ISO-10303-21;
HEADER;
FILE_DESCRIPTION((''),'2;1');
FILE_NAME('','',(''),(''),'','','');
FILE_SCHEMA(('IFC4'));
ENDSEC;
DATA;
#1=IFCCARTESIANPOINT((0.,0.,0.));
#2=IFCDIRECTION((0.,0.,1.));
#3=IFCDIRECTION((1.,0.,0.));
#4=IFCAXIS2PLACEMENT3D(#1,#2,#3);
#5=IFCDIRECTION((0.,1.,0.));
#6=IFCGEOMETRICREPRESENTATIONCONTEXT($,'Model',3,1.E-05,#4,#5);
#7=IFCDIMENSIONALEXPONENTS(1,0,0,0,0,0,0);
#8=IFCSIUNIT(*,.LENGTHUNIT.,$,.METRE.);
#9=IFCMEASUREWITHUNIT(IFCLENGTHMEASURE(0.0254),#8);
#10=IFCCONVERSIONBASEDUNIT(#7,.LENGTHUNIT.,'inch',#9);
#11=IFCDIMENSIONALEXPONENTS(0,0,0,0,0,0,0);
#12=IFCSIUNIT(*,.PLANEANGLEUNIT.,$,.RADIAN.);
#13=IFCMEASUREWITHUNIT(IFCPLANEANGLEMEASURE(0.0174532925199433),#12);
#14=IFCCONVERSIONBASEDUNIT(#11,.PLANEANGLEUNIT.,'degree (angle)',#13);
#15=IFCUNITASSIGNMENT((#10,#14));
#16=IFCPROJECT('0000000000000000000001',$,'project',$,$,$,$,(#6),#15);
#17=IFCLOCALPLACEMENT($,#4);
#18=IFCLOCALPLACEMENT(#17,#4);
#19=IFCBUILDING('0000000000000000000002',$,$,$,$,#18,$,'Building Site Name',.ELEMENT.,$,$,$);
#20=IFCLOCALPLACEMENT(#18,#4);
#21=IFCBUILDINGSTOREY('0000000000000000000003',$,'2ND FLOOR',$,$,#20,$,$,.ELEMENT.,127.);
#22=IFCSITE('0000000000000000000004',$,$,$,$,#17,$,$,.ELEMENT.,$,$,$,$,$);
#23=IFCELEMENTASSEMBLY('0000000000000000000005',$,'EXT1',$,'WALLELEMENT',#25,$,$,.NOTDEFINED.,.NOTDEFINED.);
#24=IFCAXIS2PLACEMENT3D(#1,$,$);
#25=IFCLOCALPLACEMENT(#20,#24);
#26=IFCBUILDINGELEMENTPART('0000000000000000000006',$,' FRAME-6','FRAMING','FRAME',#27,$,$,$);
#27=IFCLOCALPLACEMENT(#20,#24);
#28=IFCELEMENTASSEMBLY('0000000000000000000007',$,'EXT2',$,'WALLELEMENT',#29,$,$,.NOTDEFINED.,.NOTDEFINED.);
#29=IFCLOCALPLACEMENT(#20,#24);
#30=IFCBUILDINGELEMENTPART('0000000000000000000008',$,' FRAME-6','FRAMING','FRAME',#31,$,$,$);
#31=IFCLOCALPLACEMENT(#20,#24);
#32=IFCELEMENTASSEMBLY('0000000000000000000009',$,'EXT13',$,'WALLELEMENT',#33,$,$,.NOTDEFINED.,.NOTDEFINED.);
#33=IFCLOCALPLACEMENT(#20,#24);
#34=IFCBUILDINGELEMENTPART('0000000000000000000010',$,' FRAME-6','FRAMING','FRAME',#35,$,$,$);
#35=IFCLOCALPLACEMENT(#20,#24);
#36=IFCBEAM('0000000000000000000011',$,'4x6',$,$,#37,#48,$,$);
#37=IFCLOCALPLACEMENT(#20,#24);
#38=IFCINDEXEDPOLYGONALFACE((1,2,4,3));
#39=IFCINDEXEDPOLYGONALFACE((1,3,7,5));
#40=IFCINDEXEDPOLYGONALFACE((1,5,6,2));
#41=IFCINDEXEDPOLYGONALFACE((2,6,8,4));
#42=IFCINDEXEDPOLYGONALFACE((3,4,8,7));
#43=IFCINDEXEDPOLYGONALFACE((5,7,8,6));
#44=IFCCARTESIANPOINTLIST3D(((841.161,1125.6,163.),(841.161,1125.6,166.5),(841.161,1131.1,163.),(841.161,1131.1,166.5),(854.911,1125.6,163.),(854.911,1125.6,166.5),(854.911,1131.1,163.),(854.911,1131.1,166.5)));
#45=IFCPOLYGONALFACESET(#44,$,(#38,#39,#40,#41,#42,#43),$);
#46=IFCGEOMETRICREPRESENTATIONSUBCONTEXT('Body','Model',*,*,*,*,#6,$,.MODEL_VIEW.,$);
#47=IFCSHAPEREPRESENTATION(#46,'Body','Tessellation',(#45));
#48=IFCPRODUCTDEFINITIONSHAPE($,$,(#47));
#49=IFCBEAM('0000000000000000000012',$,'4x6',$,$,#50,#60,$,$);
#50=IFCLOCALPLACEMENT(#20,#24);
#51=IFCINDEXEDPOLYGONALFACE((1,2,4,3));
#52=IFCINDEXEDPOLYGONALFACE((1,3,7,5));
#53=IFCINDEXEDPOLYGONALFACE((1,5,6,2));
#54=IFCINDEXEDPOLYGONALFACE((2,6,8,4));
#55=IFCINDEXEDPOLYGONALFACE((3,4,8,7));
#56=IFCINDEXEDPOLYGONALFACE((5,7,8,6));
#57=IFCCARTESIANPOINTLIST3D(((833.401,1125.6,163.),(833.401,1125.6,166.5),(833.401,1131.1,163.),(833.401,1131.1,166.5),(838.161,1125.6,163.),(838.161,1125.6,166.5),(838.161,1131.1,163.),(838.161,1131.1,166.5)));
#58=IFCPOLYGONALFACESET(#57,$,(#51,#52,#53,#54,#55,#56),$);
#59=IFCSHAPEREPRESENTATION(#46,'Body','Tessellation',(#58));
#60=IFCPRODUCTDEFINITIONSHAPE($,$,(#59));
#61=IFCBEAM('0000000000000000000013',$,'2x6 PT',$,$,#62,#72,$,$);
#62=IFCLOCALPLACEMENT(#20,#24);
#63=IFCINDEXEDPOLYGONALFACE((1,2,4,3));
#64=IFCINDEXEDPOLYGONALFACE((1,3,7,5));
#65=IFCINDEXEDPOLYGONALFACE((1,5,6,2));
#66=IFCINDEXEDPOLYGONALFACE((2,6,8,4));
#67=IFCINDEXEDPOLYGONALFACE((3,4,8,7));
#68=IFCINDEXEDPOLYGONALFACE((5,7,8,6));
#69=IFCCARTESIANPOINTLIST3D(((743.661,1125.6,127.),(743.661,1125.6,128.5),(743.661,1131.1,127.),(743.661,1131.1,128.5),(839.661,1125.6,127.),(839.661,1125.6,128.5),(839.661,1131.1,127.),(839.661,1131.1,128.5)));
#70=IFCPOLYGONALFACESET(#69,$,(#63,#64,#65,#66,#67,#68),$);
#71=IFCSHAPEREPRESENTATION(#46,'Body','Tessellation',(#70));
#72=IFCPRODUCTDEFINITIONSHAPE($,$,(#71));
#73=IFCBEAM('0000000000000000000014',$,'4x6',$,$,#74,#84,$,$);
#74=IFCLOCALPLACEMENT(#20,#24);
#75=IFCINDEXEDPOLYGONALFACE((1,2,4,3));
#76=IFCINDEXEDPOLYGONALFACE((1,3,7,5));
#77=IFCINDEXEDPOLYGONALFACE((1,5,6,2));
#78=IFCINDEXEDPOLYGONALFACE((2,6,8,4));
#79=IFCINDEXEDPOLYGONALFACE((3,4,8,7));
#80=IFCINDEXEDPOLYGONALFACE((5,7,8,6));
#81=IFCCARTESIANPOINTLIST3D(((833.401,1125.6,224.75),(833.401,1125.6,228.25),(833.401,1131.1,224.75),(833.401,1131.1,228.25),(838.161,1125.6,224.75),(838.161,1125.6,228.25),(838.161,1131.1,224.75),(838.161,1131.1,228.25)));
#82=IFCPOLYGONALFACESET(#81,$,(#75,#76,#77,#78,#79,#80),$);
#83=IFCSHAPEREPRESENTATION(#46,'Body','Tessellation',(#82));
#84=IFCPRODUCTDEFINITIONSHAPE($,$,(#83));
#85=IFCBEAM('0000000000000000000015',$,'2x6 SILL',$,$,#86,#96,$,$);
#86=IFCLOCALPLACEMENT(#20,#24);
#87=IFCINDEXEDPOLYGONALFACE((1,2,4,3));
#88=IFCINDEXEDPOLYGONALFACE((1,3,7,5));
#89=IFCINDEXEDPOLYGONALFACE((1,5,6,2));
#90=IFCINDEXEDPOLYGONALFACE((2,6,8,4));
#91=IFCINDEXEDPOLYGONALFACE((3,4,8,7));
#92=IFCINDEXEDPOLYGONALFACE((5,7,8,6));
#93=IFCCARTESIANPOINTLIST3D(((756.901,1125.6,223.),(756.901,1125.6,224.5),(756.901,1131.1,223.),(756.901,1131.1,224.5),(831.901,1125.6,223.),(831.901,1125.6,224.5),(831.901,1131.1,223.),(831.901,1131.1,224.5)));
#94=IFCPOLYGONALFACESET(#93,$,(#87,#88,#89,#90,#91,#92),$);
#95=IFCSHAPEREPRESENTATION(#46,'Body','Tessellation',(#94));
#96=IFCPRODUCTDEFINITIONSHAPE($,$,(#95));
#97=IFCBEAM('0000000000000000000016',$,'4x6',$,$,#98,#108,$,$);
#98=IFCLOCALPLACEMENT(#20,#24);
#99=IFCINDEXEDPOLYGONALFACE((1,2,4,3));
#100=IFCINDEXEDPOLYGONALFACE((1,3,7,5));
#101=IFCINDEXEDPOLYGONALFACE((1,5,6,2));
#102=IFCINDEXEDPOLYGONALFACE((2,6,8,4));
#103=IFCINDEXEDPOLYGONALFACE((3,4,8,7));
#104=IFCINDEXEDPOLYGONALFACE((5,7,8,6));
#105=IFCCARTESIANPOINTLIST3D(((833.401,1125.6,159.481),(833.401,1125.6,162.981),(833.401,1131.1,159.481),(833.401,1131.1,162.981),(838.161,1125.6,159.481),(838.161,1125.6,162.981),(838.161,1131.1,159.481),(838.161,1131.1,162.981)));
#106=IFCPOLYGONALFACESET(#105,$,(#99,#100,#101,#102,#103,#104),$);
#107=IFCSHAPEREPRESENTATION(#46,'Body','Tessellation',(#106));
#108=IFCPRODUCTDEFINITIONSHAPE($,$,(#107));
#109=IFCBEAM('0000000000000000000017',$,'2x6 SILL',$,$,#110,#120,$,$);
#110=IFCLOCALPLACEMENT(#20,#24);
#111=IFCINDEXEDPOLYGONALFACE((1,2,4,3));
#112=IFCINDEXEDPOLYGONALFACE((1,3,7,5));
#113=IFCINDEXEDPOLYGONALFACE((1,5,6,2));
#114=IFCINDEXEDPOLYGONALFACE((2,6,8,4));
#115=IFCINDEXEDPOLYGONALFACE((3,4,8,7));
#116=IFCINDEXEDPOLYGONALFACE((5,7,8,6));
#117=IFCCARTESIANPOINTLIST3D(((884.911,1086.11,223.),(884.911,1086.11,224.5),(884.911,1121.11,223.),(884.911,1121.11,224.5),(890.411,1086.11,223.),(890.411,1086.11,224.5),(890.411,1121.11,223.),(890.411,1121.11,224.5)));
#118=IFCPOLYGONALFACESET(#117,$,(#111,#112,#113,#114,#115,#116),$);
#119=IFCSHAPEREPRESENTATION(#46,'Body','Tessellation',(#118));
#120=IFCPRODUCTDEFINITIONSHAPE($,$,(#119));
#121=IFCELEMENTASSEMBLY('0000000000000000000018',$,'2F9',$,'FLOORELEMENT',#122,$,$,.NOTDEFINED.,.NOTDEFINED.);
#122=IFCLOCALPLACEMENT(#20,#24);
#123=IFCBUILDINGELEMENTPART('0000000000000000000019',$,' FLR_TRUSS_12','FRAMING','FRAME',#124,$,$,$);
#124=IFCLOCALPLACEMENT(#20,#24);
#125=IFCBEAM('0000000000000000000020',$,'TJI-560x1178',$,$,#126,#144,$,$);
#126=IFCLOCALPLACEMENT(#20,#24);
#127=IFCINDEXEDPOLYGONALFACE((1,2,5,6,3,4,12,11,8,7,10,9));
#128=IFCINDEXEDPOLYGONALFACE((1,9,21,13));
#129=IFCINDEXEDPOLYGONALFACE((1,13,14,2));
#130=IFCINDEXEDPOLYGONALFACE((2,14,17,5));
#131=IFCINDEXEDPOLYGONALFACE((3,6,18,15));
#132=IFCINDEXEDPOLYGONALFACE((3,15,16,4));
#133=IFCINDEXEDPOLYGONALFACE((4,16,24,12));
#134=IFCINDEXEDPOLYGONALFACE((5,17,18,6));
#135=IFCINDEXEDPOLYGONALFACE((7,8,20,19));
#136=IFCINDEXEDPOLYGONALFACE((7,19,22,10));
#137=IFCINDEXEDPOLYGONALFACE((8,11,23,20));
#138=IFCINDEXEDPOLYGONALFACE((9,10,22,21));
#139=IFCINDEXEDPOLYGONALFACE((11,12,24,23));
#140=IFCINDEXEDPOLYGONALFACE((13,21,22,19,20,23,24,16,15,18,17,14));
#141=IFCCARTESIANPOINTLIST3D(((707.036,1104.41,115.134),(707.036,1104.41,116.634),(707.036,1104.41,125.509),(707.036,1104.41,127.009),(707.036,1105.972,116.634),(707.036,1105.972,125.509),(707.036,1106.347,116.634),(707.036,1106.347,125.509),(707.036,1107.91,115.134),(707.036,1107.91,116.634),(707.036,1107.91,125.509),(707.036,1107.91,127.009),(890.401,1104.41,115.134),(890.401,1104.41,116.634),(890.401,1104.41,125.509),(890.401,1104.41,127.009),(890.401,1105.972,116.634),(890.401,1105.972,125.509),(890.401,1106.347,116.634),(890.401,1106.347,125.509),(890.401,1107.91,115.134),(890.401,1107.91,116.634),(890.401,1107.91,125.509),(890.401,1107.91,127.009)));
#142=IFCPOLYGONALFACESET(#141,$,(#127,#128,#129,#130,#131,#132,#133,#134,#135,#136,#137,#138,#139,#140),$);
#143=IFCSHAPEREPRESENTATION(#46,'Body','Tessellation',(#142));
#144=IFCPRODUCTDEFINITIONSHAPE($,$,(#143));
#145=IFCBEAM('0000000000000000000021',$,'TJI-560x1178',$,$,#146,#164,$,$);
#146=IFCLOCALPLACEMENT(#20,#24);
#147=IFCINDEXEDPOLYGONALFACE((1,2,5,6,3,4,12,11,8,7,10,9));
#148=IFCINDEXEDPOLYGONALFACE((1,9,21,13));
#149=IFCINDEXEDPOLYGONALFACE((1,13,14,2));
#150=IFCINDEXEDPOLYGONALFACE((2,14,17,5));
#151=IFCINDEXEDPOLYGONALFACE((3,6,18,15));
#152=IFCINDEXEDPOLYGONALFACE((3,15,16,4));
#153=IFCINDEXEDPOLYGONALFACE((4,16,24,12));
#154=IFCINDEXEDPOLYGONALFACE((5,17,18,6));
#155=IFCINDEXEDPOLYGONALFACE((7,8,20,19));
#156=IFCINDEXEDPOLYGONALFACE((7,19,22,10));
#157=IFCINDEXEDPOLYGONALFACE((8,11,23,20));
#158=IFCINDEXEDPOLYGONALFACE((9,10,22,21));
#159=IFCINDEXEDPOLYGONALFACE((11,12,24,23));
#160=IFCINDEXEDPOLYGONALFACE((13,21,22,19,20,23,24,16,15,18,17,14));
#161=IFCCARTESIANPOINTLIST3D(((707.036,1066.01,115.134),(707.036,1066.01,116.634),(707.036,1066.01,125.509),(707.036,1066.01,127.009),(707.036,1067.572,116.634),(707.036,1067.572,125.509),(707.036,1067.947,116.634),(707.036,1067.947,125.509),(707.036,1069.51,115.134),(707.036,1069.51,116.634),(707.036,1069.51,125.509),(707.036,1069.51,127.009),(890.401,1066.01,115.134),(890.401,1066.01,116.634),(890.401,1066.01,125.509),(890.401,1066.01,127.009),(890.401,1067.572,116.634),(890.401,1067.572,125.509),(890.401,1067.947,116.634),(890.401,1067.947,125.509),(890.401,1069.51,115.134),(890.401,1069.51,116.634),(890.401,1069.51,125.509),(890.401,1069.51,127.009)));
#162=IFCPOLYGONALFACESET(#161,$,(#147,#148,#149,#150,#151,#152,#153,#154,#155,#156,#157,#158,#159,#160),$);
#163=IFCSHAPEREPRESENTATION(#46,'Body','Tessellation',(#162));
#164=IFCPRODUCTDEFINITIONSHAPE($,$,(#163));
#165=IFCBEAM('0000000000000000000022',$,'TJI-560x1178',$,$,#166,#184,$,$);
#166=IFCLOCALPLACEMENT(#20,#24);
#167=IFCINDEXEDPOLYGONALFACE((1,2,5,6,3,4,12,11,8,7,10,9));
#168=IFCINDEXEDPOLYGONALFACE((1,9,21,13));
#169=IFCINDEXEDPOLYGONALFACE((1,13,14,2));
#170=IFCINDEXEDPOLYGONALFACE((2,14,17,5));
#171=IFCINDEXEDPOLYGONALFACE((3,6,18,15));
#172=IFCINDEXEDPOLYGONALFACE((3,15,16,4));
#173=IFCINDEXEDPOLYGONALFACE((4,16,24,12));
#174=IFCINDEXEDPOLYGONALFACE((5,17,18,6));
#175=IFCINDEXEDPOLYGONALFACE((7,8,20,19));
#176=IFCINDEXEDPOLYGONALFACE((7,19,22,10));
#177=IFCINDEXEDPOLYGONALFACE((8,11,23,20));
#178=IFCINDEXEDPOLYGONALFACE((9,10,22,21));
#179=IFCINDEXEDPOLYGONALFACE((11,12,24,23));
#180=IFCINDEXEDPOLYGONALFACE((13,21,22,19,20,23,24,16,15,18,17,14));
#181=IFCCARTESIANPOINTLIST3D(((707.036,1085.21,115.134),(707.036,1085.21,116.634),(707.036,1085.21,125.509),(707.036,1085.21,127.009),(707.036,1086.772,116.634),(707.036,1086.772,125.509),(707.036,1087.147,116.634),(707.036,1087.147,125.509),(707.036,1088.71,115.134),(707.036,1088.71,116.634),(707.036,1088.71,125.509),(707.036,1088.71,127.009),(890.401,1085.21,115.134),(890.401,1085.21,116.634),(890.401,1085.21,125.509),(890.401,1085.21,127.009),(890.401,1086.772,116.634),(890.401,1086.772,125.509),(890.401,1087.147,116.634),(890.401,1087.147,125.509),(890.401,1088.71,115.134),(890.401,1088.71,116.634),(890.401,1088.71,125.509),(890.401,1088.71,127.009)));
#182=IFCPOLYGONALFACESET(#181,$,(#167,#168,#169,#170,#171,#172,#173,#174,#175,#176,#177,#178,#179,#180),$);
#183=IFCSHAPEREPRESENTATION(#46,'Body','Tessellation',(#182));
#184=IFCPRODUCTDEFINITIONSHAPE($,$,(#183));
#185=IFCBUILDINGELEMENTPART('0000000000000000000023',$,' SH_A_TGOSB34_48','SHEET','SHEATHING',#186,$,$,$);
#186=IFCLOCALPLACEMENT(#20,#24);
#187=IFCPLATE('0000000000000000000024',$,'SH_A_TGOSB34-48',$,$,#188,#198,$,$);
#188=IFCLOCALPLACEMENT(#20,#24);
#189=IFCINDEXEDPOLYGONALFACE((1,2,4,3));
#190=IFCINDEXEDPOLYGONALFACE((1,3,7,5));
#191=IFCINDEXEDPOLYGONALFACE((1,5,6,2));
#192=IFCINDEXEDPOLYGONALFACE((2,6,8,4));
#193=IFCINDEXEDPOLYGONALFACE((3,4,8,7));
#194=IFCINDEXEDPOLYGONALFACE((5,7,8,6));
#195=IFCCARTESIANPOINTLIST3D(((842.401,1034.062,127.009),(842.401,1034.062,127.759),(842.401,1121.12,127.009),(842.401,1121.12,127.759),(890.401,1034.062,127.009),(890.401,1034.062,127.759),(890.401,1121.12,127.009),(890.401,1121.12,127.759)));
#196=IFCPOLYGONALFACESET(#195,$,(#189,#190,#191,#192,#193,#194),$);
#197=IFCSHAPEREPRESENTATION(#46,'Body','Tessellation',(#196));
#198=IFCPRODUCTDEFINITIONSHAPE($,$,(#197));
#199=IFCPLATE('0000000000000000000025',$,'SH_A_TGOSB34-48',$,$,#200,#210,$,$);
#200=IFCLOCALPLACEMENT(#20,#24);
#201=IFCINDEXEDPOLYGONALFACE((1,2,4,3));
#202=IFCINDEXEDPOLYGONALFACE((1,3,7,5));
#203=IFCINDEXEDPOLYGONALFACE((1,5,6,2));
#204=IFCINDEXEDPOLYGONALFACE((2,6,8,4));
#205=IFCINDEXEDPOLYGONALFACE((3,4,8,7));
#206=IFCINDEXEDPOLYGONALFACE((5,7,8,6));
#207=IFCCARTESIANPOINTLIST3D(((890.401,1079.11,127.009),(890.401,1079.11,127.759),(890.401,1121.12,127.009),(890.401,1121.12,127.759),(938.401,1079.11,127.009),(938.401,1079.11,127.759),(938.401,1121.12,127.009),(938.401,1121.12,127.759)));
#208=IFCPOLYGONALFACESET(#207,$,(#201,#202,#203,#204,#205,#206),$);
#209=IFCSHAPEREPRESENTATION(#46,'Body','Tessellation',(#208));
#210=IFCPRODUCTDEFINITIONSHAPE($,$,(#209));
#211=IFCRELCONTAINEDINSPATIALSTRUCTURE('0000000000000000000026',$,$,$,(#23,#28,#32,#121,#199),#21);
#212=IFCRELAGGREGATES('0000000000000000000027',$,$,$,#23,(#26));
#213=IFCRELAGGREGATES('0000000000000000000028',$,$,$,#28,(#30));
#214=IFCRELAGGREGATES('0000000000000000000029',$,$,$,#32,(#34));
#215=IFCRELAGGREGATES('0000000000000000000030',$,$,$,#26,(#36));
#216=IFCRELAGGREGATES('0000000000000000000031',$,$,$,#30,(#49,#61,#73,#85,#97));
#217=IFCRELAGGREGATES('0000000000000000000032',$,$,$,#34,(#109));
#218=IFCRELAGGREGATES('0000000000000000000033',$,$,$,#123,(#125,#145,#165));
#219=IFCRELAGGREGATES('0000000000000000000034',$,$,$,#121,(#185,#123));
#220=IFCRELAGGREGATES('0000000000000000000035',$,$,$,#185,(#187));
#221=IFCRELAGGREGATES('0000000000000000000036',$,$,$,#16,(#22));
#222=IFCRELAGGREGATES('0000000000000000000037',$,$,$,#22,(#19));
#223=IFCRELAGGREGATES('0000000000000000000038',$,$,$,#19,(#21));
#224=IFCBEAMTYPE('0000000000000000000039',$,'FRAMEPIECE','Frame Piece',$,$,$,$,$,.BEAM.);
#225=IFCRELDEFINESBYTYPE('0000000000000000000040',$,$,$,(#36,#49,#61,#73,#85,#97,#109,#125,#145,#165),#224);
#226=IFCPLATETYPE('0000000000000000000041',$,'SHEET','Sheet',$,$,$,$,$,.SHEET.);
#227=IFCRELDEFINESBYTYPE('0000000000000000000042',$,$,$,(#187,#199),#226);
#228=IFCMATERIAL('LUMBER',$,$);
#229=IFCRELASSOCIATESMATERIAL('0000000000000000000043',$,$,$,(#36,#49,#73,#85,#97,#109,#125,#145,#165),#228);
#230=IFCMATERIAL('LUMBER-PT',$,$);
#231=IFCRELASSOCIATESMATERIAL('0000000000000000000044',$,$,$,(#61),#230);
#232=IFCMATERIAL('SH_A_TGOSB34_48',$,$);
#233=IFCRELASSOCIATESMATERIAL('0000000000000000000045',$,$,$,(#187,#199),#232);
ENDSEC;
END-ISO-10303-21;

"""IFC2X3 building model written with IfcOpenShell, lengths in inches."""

from ifc_helpers import new_model, entity, si_unit, converted_unit, direction, frame, frame_2d, origin_with_axes, origin_2d_with_axis, place, context, subcontext, project, spatial, polyline, segment, composite_curve, rectangle, i_section, outline, extrude, material, type_object, element, aggregate, save


model = new_model("IFC2X3")

# Units and contexts
model_context = context("Model", 3, precision=1e-05, world=origin_with_axes(), true_north=direction((0.0, 1.0, 0.0)))
body_context = subcontext(model_context, "Body", "Model", "MODEL_VIEW")
ifc_project = project(units=[converted_unit("LENGTHUNIT", "inch", entity("IfcLengthMeasure", 0.0254), si_unit("LENGTHUNIT", "METRE"), dimensions=[1, 0, 0, 0, 0, 0, 0]), converted_unit("PLANEANGLEUNIT", "degree (angle)", entity("IfcPlaneAngleMeasure", 0.0174532925199433), si_unit("PLANEANGLEUNIT", "RADIAN"), dimensions=[0, 0, 0, 0, 0, 0, 0])], contexts=[model_context])

# Site, building, storey
site_placement = place(None, origin_with_axes())
site = spatial("IfcSite", under=ifc_project, at=site_placement, CompositionType="ELEMENT")
building_placement = place(site_placement, origin_with_axes())
building = spatial("IfcBuilding", under=site, at=building_placement, LongName="Building Site Name", CompositionType="ELEMENT")
storey_placement = place(building_placement, origin_with_axes())
storey = spatial("IfcBuildingStorey", under=building, at=storey_placement, Name="2ND FLOOR", CompositionType="ELEMENT", Elevation=127.0)

# Element assembly, building element part
assembly_1_placement = place(storey_placement, origin_with_axes())
assembly_1 = element("IfcElementAssembly", 1, at=assembly_1_placement, inside=storey, Name="EXT1", ObjectType="WALLELEMENT", AssemblyPlace="NOTDEFINED", PredefinedType="NOTDEFINED")
building_element_part_1 = element("IfcBuildingElementPart", 2, Name=" FRAME-6", Description="FRAMING", ObjectType="FRAME")
aggregate(assembly_1, [building_element_part_1])
ifc_material_1 = material(Name="LUMBER")
beam_type = type_object("IfcBeamType", Name="FRAMEPIECE", Description="Frame Piece", PredefinedType="BEAM")

# Element assemblies, building element parts
assembly_2_placement = place(storey_placement, origin_with_axes())
assembly_2 = element("IfcElementAssembly", 3, at=assembly_2_placement, inside=storey, Name="EXT2", ObjectType="WALLELEMENT", AssemblyPlace="NOTDEFINED", PredefinedType="NOTDEFINED")
building_element_part_2 = element("IfcBuildingElementPart", 4, Name=" FRAME-6", Description="FRAMING", ObjectType="FRAME")
aggregate(assembly_2, [building_element_part_2])
assembly_3_placement = place(storey_placement, origin_with_axes())
assembly_3 = element("IfcElementAssembly", 5, at=assembly_3_placement, inside=storey, Name="EXT13", ObjectType="WALLELEMENT", AssemblyPlace="NOTDEFINED", PredefinedType="NOTDEFINED")
building_element_part_3 = element("IfcBuildingElementPart", 6, Name=" FRAME-6", Description="FRAMING", ObjectType="FRAME")
aggregate(assembly_3, [building_element_part_3])

# Beams
ifc_material_2 = material(Name="LUMBER-PT")
beam_1_placement = place(assembly_1_placement, frame((841.161, 1128.35, 164.75), z_axis=(1.0, 0.0, 0.0), x_axis=(0.0, 0.0, -1.0)))
beam_1 = element("IfcBeam", 7, at=beam_1_placement, type_object=beam_type, material=ifc_material_1, Name="4x6", context=body_context, shape_type="SweptSolid", body=[
    extrude(outline(composite_curve([segment(polyline([(-1.75, -2.75), (-1.75, 2.75), (1.75, 2.75), (1.75, -2.75), (-1.75, -2.75)]), True, "CONTINUOUS")], self_intersect=False)), origin_with_axes(), (0.0, 0.0, 1.0), 13.75),
])
aggregate(building_element_part_1, [beam_1])
beam_2_placement = place(assembly_2_placement, frame((833.401, 1128.35, 164.75), z_axis=(1.0, 0.0, 0.0), x_axis=(0.0, 0.0, -1.0)))
beam_2 = element("IfcBeam", 8, at=beam_2_placement, type_object=beam_type, material=ifc_material_1, Name="4x6", context=body_context, shape_type="SweptSolid", body=[
    extrude(outline(composite_curve([segment(polyline([(-1.75, -2.75), (-1.75, 2.75), (1.75, 2.75), (1.75, -2.75), (-1.75, -2.75)]), True, "CONTINUOUS")], self_intersect=False)), origin_with_axes(), (0.0, 0.0, 1.0), 4.76),
])
beam_3_placement = place(assembly_2_placement, frame((839.661, 1128.35, 127.75), z_axis=(-1.0, 0.0, 0.0), x_axis=(0.0, 0.0, 1.0)))
beam_3 = element("IfcBeam", 9, at=beam_3_placement, type_object=beam_type, material=ifc_material_2, Name="2x6 PT", context=body_context, shape_type="SweptSolid", body=[
    extrude(rectangle(XDim=1.5, YDim=5.5, at=frame_2d((0.0, 0.0), x_axis=(-1.0, 0.0))), origin_with_axes(), (0.0, 0.0, 1.0), 96.0),
])
beam_4_placement = place(assembly_2_placement, frame((833.401, 1128.35, 226.5), z_axis=(1.0, 0.0, 0.0), x_axis=(0.0, 0.0, -1.0)))
beam_4 = element("IfcBeam", 10, at=beam_4_placement, type_object=beam_type, material=ifc_material_1, Name="4x6", context=body_context, shape_type="SweptSolid", body=[
    extrude(outline(composite_curve([segment(polyline([(-1.75, -2.75), (-1.75, 2.75), (1.75, 2.75), (1.75, -2.75), (-1.75, -2.75)]), True, "CONTINUOUS")], self_intersect=False)), origin_with_axes(), (0.0, 0.0, 1.0), 4.76),
])
beam_5_placement = place(assembly_2_placement, frame((831.901, 1128.35, 223.75), z_axis=(-1.0, 0.0, 0.0), x_axis=(0.0, 0.0, 1.0)))
beam_5 = element("IfcBeam", 11, at=beam_5_placement, type_object=beam_type, material=ifc_material_1, Name="2x6 SILL", context=body_context, shape_type="SweptSolid", body=[
    extrude(rectangle(XDim=1.5, YDim=5.5, at=frame_2d((0.0, 0.0), x_axis=(-1.0, 0.0))), frame((0.0, 0.0, 0.0), z_axis=(0.0, 0.0, 1.0), x_axis=(1.0, 0.0, 0.0)), (0.0, 0.0, 1.0), 75.0),
])
beam_6_placement = place(assembly_2_placement, frame((833.401, 1128.35, 161.231), z_axis=(1.0, 0.0, 0.0), x_axis=(0.0, 0.0, -1.0)))
beam_6 = element("IfcBeam", 12, at=beam_6_placement, type_object=beam_type, material=ifc_material_1, Name="4x6", context=body_context, shape_type="SweptSolid", body=[
    extrude(outline(composite_curve([segment(polyline([(-1.75, -2.75), (-1.75, 2.75), (1.75, 2.75), (1.75, -2.75), (-1.75, -2.75)]), True, "CONTINUOUS")], self_intersect=False)), origin_with_axes(), (0.0, 0.0, 1.0), 4.76),
])
aggregate(building_element_part_2, [beam_2, beam_3, beam_4, beam_5, beam_6])
beam_7_placement = place(assembly_3_placement, frame((887.661, 1086.11, 223.75), z_axis=(0.0, 1.0, 0.0), x_axis=(0.0, 0.0, 1.0)))
beam_7 = element("IfcBeam", 13, at=beam_7_placement, type_object=beam_type, material=ifc_material_1, Name="2x6 SILL", context=body_context, shape_type="SweptSolid", body=[
    extrude(rectangle(XDim=1.5, YDim=5.5, at=frame_2d((0.0, 0.0), x_axis=(-1.0, 0.0))), frame((0.0, 0.0, 0.0), z_axis=(0.0, 0.0, 1.0), x_axis=(1.0, 0.0, 0.0)), (0.0, 0.0, 1.0), 35.0),
])
aggregate(building_element_part_3, [beam_7])

# Element assembly, building element parts, beams, plate
assembly_4_placement = place(storey_placement, origin_with_axes())
assembly_4 = element("IfcElementAssembly", 14, at=assembly_4_placement, inside=storey, Name="2F9", ObjectType="FLOORELEMENT", AssemblyPlace="NOTDEFINED", PredefinedType="NOTDEFINED")
building_element_part_4 = element("IfcBuildingElementPart", 15, Name=" FLR_TRUSS_12", Description="FRAMING", ObjectType="FRAME")
beam_8_placement = place(assembly_4_placement, frame((890.401, 1106.16, 121.071), z_axis=(-1.0, 0.0, 0.0), x_axis=(0.0, -1.0, 0.0)))
beam_8 = element("IfcBeam", 16, at=beam_8_placement, type_object=beam_type, material=ifc_material_1, Name="TJI-560x1178", context=body_context, shape_type="SweptSolid", body=[
    extrude(i_section(OverallWidth=3.5, OverallDepth=11.875, WebThickness=0.375, FlangeThickness=1.5, FilletRadius=0.0, at=origin_2d_with_axis()), frame((0.0, 0.0, 0.0), z_axis=(0.0, 0.0, 1.0), x_axis=(1.0, 0.0, 0.0)), (0.0, 0.0, 1.0), 183.365),
])
beam_9_placement = place(assembly_4_placement, frame((890.401, 1067.76, 121.071), z_axis=(-1.0, 0.0, 0.0), x_axis=(0.0, -1.0, 0.0)))
beam_9 = element("IfcBeam", 17, at=beam_9_placement, type_object=beam_type, material=ifc_material_1, Name="TJI-560x1178", context=body_context, shape_type="SweptSolid", body=[
    extrude(i_section(OverallWidth=3.5, OverallDepth=11.875, WebThickness=0.375, FlangeThickness=1.5, FilletRadius=0.0, at=origin_2d_with_axis()), frame((0.0, 0.0, 0.0), z_axis=(0.0, 0.0, 1.0), x_axis=(1.0, 0.0, 0.0)), (0.0, 0.0, 1.0), 183.365),
])
beam_10_placement = place(assembly_4_placement, frame((890.401, 1086.96, 121.071), z_axis=(-1.0, 0.0, 0.0), x_axis=(0.0, -1.0, 0.0)))
beam_10 = element("IfcBeam", 18, at=beam_10_placement, type_object=beam_type, material=ifc_material_1, Name="TJI-560x1178", context=body_context, shape_type="SweptSolid", body=[
    extrude(i_section(OverallWidth=3.5, OverallDepth=11.875, WebThickness=0.375, FlangeThickness=1.5, FilletRadius=0.0, at=origin_2d_with_axis()), frame((0.0, 0.0, 0.0), z_axis=(0.0, 0.0, 1.0), x_axis=(1.0, 0.0, 0.0)), (0.0, 0.0, 1.0), 183.365),
])
aggregate(building_element_part_4, [beam_8, beam_9, beam_10])
building_element_part_5 = element("IfcBuildingElementPart", 19, Name=" SH_A_TGOSB34_48", Description="SHEET", ObjectType="SHEATHING")
aggregate(assembly_4, [building_element_part_5, building_element_part_4])
ifc_material_3 = material(Name="SH_A_TGOSB34_48")
plate_type = type_object("IfcPlateType", Name="SHEET", Description="Sheet", PredefinedType="SHEET")
plate_1_placement = place(assembly_4_placement, frame((866.401, 1082.062, 127.759), z_axis=(0.0, 0.0, 1.0), x_axis=(-1.0, 0.0, 0.0)))
plate_1 = element("IfcPlate", 20, at=plate_1_placement, type_object=plate_type, material=ifc_material_3, Name="SH_A_TGOSB34-48", context=body_context, shape_type="SweptSolid", body=[
    extrude(rectangle(XDim=0.75, YDim=48.0, at=frame_2d((0.0, -0.375), x_axis=(0.0, -1.0))), frame((0.0, -39.057, 0.0), z_axis=(0.0, 1.0, 0.0), x_axis=(-1.0, 0.0, 0.0)), (0.0, 0.0, 1.0), 87.057),
])
aggregate(building_element_part_5, [plate_1])

# Plate
plate_2_placement = place(storey_placement, frame((890.401, 1103.11, 127.759), z_axis=(0.0, 0.0, 1.0), x_axis=(0.0, 1.0, 0.0)))
element("IfcPlate", 21, at=plate_2_placement, inside=storey, type_object=plate_type, material=ifc_material_3, Name="SH_A_TGOSB34-48", context=body_context, shape_type="SweptSolid", body=[
    extrude(rectangle(XDim=0.75, YDim=42.01, at=frame_2d((2.995, -0.375), x_axis=(0.0, -1.0))), frame((0.0, -48.0, 0.0), z_axis=(0.0, 1.0, 0.0), x_axis=(-1.0, 0.0, 0.0)), (0.0, 0.0, 1.0), 48.0),
])

save(model, "model.ifc")
